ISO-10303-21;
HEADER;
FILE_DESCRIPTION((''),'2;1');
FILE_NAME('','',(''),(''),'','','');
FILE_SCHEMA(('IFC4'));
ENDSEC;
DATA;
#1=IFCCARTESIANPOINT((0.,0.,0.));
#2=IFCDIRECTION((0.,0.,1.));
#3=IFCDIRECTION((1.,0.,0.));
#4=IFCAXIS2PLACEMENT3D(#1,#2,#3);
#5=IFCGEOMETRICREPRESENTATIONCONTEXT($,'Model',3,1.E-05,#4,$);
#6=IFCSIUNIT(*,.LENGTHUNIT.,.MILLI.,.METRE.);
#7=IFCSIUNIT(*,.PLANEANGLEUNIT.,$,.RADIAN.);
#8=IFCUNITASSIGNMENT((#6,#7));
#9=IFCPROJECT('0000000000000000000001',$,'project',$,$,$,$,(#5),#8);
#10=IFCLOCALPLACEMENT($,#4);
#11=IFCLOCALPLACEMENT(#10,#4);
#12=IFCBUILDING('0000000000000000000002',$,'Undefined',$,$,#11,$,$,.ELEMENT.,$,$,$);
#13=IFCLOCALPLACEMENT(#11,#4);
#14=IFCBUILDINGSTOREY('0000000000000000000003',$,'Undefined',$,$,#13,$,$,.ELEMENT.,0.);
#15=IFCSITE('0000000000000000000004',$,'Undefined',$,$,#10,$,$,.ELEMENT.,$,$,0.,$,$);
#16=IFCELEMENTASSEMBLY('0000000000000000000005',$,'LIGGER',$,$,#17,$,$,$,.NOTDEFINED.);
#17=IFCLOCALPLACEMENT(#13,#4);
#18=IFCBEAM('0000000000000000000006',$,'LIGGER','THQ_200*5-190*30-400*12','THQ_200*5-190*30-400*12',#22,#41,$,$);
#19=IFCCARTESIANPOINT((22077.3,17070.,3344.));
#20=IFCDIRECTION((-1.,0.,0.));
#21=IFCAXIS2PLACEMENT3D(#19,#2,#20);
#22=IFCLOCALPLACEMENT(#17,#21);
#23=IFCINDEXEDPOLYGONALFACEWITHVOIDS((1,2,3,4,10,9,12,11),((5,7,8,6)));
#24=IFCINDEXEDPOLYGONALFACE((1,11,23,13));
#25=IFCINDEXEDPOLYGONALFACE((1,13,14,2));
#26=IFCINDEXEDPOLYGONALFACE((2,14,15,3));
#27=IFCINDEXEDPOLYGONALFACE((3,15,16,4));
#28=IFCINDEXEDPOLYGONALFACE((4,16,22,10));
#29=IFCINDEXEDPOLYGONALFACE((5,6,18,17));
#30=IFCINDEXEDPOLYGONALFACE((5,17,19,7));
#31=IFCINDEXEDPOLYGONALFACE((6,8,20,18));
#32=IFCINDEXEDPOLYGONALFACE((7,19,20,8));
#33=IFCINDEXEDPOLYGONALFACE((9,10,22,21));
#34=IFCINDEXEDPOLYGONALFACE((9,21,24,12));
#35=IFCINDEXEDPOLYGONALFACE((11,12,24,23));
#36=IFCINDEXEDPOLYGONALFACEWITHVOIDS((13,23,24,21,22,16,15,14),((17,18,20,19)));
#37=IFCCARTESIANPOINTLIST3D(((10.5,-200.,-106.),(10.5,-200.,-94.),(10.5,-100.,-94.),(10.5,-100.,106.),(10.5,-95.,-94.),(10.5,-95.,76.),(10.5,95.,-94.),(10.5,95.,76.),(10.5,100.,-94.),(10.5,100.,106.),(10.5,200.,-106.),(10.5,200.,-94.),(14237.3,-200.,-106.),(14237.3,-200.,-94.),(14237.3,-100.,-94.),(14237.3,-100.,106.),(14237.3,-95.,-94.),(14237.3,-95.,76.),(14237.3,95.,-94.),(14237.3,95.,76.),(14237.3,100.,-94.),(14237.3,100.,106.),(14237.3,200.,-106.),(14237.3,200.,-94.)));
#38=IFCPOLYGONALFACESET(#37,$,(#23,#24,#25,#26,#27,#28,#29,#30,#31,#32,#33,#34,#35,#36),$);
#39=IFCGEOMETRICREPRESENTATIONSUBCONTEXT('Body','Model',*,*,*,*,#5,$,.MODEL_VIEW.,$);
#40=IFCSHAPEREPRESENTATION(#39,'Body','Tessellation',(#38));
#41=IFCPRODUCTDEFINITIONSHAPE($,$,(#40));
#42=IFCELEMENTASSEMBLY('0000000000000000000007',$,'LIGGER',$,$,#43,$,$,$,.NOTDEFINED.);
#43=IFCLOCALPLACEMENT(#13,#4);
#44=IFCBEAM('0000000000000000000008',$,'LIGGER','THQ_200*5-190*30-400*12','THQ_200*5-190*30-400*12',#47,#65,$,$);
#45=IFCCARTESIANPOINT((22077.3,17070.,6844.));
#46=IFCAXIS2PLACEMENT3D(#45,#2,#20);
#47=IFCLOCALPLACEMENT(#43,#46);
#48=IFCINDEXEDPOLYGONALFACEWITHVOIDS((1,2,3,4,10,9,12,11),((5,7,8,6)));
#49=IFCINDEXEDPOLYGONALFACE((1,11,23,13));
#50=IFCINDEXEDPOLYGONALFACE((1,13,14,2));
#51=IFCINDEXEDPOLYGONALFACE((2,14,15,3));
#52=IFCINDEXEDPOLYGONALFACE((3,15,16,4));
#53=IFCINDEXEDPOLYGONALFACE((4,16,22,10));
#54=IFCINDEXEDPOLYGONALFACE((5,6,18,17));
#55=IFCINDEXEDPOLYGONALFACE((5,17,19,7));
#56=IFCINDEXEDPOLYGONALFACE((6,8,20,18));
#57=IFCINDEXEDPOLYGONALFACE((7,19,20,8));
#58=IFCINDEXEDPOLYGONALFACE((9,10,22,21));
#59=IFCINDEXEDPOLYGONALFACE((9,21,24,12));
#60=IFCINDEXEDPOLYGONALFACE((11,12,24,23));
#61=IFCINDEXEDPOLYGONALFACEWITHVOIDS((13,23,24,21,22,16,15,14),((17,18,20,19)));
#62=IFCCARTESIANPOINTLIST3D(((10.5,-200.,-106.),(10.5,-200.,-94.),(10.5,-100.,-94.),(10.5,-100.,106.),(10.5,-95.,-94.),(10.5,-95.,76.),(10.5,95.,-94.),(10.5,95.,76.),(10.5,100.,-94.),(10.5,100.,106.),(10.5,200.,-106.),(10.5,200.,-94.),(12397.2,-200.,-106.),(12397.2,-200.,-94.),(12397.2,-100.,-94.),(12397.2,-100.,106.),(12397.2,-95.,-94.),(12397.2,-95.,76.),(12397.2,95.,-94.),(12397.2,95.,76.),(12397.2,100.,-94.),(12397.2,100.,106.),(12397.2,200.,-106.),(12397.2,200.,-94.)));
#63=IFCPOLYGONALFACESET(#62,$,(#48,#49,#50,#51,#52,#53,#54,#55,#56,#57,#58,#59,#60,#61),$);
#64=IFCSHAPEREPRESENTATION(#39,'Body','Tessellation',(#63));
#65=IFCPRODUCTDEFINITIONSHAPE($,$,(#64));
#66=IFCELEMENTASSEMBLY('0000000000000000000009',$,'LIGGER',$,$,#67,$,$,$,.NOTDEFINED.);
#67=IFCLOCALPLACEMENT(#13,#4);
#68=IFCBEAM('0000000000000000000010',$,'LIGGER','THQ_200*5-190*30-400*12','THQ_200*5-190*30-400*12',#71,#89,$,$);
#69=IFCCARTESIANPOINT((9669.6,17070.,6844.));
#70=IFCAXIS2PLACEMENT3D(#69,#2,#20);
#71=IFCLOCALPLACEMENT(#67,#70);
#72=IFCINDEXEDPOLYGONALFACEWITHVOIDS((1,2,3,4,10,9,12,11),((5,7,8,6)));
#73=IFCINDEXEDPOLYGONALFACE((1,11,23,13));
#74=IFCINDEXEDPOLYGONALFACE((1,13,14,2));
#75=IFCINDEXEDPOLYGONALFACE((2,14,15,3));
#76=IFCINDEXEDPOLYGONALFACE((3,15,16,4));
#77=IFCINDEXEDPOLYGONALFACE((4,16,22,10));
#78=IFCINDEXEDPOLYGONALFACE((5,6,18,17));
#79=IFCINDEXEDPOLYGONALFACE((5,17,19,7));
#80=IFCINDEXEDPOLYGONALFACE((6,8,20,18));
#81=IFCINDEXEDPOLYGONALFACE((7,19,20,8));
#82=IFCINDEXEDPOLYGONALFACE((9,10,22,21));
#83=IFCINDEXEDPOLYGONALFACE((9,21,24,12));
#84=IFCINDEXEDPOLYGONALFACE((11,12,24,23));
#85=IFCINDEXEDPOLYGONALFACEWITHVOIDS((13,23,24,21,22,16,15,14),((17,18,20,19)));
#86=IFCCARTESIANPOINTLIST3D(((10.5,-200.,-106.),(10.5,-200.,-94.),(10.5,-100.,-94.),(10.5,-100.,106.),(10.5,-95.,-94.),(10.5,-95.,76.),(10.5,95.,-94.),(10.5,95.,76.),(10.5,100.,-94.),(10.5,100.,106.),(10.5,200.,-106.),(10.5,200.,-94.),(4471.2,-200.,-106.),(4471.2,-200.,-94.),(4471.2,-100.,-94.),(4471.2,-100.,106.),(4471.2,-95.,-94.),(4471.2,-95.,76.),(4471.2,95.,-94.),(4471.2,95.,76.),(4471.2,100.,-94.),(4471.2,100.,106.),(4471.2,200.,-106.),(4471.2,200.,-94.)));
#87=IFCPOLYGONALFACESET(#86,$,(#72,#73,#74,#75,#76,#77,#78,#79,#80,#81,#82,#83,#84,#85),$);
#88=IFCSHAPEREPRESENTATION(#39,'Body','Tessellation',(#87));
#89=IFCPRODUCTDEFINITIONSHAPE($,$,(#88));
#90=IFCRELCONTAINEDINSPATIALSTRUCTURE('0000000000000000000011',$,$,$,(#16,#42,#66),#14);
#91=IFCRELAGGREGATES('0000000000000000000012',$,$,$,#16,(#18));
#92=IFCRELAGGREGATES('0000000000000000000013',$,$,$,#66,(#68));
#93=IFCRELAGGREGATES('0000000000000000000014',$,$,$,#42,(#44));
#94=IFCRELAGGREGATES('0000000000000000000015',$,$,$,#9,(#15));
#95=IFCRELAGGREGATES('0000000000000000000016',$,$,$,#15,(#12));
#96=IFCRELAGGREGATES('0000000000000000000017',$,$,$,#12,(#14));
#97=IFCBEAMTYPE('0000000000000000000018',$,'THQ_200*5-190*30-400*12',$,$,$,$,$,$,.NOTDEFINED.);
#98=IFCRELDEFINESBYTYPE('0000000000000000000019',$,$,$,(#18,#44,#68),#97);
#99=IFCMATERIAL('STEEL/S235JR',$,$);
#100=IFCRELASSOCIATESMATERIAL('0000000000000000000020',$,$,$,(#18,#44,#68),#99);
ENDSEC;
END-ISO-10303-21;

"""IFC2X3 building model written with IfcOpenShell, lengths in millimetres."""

from ifc_helpers import new_model, si_unit, frame, origin_with_axes, place, context, subcontext, project, spatial, polyline, outline, extrude, material, type_object, element, aggregate, save


model = new_model("IFC2X3")

# Units and contexts
model_context = context("Model", 3, precision=1e-05, world=origin_with_axes())
body_context = subcontext(model_context, "Body", "Model", "MODEL_VIEW")
ifc_project = project(units=[si_unit("LENGTHUNIT", "METRE", prefix="MILLI"), si_unit("PLANEANGLEUNIT", "RADIAN")], contexts=[model_context])

# Site, building, storey
site_placement = place(None, origin_with_axes())
site = spatial("IfcSite", under=ifc_project, at=site_placement, Name="Undefined", CompositionType="ELEMENT", RefElevation=0.0)
building_placement = place(site_placement, origin_with_axes())
building = spatial("IfcBuilding", under=site, at=building_placement, Name="Undefined", CompositionType="ELEMENT")
storey_placement = place(building_placement, origin_with_axes())
storey = spatial("IfcBuildingStorey", under=building, at=storey_placement, Name="Undefined", CompositionType="ELEMENT", Elevation=0.0)

# Shared definitions
ifc_material = material(Name="STEEL/S235JR")

# Element assemblies, beams
assembly_1_placement = place(storey_placement, origin_with_axes())
assembly_1 = element("IfcElementAssembly", 1, at=assembly_1_placement, inside=storey, Name="LIGGER", PredefinedType="NOTDEFINED")
beam_type_1 = type_object("IfcBeamType", Name="THQ_200*5-190*30-400*12", PredefinedType="NOTDEFINED")
beam_1_placement = place(assembly_1_placement, frame((22077.3, 17070.0, 3344.0), z_axis=(0.0, 0.0, 1.0), x_axis=(-1.0, 0.0, 0.0)))
beam_1 = element("IfcBeam", 2, at=beam_1_placement, type_object=beam_type_1, material=ifc_material, Name="LIGGER", Description="THQ_200*5-190*30-400*12", ObjectType="THQ_200*5-190*30-400*12", context=body_context, shape_type="SweptSolid", body=[
    extrude(outline(polyline([(100.0, -94.0), (200.0, -94.0), (200.0, -106.0), (-200.0, -106.0), (-200.0, -94.0), (-100.0, -94.0), (-100.0, 106.0), (100.0, 106.0), (100.0, -94.0)]), holes=[polyline([(95.0, -94.0), (95.0, 76.0), (-95.0, 76.0), (-95.0, -94.0), (95.0, -94.0)])]), frame((14237.3, 0.0, 0.0), z_axis=(-1.0, 0.0, 0.0), x_axis=(0.0, -1.0, 0.0)), (0.0, 0.0, 1.0), 14226.8),
])
assembly_2_placement = place(storey_placement, origin_with_axes())
assembly_2 = element("IfcElementAssembly", 3, at=assembly_2_placement, inside=storey, Name="LIGGER", PredefinedType="NOTDEFINED")
beam_2_placement = place(assembly_2_placement, frame((22077.3, 17070.0, 6844.0), z_axis=(0.0, 0.0, 1.0), x_axis=(-1.0, 0.0, 0.0)))
beam_2 = element("IfcBeam", 4, at=beam_2_placement, type_object=beam_type_1, material=ifc_material, Name="LIGGER", Description="THQ_200*5-190*30-400*12", ObjectType="THQ_200*5-190*30-400*12", context=body_context, shape_type="SweptSolid", body=[
    extrude(outline(polyline([(100.0, -94.0), (200.0, -94.0), (200.0, -106.0), (-200.0, -106.0), (-200.0, -94.0), (-100.0, -94.0), (-100.0, 106.0), (100.0, 106.0), (100.0, -94.0)]), holes=[polyline([(95.0, -94.0), (95.0, 76.0), (-95.0, 76.0), (-95.0, -94.0), (95.0, -94.0)])]), frame((12397.2, 0.0, 0.0), z_axis=(-1.0, 0.0, 0.0), x_axis=(0.0, -1.0, 0.0)), (0.0, 0.0, 1.0), 12386.7),
])
assembly_3_placement = place(storey_placement, origin_with_axes())
assembly_3 = element("IfcElementAssembly", 5, at=assembly_3_placement, inside=storey, Name="LIGGER", PredefinedType="NOTDEFINED")
beam_3_placement = place(assembly_3_placement, frame((9669.6, 17070.0, 6844.0), z_axis=(0.0, 0.0, 1.0), x_axis=(-1.0, 0.0, 0.0)))
beam_3 = element("IfcBeam", 6, at=beam_3_placement, type_object=beam_type_1, material=ifc_material, Name="LIGGER", Description="THQ_200*5-190*30-400*12", ObjectType="THQ_200*5-190*30-400*12", context=body_context, shape_type="SweptSolid", body=[
    extrude(outline(polyline([(100.0, -94.0), (200.0, -94.0), (200.0, -106.0), (-200.0, -106.0), (-200.0, -94.0), (-100.0, -94.0), (-100.0, 106.0), (100.0, 106.0), (100.0, -94.0)]), holes=[polyline([(95.0, -94.0), (95.0, 76.0), (-95.0, 76.0), (-95.0, -94.0), (95.0, -94.0)])]), frame((4471.2, 0.0, 0.0), z_axis=(-1.0, 0.0, 0.0), x_axis=(0.0, -1.0, 0.0)), (0.0, 0.0, 1.0), 4460.7),
])

aggregate(assembly_1, [beam_1])

aggregate(assembly_3, [beam_3])
aggregate(assembly_2, [beam_2])

save(model, "model.ifc")
